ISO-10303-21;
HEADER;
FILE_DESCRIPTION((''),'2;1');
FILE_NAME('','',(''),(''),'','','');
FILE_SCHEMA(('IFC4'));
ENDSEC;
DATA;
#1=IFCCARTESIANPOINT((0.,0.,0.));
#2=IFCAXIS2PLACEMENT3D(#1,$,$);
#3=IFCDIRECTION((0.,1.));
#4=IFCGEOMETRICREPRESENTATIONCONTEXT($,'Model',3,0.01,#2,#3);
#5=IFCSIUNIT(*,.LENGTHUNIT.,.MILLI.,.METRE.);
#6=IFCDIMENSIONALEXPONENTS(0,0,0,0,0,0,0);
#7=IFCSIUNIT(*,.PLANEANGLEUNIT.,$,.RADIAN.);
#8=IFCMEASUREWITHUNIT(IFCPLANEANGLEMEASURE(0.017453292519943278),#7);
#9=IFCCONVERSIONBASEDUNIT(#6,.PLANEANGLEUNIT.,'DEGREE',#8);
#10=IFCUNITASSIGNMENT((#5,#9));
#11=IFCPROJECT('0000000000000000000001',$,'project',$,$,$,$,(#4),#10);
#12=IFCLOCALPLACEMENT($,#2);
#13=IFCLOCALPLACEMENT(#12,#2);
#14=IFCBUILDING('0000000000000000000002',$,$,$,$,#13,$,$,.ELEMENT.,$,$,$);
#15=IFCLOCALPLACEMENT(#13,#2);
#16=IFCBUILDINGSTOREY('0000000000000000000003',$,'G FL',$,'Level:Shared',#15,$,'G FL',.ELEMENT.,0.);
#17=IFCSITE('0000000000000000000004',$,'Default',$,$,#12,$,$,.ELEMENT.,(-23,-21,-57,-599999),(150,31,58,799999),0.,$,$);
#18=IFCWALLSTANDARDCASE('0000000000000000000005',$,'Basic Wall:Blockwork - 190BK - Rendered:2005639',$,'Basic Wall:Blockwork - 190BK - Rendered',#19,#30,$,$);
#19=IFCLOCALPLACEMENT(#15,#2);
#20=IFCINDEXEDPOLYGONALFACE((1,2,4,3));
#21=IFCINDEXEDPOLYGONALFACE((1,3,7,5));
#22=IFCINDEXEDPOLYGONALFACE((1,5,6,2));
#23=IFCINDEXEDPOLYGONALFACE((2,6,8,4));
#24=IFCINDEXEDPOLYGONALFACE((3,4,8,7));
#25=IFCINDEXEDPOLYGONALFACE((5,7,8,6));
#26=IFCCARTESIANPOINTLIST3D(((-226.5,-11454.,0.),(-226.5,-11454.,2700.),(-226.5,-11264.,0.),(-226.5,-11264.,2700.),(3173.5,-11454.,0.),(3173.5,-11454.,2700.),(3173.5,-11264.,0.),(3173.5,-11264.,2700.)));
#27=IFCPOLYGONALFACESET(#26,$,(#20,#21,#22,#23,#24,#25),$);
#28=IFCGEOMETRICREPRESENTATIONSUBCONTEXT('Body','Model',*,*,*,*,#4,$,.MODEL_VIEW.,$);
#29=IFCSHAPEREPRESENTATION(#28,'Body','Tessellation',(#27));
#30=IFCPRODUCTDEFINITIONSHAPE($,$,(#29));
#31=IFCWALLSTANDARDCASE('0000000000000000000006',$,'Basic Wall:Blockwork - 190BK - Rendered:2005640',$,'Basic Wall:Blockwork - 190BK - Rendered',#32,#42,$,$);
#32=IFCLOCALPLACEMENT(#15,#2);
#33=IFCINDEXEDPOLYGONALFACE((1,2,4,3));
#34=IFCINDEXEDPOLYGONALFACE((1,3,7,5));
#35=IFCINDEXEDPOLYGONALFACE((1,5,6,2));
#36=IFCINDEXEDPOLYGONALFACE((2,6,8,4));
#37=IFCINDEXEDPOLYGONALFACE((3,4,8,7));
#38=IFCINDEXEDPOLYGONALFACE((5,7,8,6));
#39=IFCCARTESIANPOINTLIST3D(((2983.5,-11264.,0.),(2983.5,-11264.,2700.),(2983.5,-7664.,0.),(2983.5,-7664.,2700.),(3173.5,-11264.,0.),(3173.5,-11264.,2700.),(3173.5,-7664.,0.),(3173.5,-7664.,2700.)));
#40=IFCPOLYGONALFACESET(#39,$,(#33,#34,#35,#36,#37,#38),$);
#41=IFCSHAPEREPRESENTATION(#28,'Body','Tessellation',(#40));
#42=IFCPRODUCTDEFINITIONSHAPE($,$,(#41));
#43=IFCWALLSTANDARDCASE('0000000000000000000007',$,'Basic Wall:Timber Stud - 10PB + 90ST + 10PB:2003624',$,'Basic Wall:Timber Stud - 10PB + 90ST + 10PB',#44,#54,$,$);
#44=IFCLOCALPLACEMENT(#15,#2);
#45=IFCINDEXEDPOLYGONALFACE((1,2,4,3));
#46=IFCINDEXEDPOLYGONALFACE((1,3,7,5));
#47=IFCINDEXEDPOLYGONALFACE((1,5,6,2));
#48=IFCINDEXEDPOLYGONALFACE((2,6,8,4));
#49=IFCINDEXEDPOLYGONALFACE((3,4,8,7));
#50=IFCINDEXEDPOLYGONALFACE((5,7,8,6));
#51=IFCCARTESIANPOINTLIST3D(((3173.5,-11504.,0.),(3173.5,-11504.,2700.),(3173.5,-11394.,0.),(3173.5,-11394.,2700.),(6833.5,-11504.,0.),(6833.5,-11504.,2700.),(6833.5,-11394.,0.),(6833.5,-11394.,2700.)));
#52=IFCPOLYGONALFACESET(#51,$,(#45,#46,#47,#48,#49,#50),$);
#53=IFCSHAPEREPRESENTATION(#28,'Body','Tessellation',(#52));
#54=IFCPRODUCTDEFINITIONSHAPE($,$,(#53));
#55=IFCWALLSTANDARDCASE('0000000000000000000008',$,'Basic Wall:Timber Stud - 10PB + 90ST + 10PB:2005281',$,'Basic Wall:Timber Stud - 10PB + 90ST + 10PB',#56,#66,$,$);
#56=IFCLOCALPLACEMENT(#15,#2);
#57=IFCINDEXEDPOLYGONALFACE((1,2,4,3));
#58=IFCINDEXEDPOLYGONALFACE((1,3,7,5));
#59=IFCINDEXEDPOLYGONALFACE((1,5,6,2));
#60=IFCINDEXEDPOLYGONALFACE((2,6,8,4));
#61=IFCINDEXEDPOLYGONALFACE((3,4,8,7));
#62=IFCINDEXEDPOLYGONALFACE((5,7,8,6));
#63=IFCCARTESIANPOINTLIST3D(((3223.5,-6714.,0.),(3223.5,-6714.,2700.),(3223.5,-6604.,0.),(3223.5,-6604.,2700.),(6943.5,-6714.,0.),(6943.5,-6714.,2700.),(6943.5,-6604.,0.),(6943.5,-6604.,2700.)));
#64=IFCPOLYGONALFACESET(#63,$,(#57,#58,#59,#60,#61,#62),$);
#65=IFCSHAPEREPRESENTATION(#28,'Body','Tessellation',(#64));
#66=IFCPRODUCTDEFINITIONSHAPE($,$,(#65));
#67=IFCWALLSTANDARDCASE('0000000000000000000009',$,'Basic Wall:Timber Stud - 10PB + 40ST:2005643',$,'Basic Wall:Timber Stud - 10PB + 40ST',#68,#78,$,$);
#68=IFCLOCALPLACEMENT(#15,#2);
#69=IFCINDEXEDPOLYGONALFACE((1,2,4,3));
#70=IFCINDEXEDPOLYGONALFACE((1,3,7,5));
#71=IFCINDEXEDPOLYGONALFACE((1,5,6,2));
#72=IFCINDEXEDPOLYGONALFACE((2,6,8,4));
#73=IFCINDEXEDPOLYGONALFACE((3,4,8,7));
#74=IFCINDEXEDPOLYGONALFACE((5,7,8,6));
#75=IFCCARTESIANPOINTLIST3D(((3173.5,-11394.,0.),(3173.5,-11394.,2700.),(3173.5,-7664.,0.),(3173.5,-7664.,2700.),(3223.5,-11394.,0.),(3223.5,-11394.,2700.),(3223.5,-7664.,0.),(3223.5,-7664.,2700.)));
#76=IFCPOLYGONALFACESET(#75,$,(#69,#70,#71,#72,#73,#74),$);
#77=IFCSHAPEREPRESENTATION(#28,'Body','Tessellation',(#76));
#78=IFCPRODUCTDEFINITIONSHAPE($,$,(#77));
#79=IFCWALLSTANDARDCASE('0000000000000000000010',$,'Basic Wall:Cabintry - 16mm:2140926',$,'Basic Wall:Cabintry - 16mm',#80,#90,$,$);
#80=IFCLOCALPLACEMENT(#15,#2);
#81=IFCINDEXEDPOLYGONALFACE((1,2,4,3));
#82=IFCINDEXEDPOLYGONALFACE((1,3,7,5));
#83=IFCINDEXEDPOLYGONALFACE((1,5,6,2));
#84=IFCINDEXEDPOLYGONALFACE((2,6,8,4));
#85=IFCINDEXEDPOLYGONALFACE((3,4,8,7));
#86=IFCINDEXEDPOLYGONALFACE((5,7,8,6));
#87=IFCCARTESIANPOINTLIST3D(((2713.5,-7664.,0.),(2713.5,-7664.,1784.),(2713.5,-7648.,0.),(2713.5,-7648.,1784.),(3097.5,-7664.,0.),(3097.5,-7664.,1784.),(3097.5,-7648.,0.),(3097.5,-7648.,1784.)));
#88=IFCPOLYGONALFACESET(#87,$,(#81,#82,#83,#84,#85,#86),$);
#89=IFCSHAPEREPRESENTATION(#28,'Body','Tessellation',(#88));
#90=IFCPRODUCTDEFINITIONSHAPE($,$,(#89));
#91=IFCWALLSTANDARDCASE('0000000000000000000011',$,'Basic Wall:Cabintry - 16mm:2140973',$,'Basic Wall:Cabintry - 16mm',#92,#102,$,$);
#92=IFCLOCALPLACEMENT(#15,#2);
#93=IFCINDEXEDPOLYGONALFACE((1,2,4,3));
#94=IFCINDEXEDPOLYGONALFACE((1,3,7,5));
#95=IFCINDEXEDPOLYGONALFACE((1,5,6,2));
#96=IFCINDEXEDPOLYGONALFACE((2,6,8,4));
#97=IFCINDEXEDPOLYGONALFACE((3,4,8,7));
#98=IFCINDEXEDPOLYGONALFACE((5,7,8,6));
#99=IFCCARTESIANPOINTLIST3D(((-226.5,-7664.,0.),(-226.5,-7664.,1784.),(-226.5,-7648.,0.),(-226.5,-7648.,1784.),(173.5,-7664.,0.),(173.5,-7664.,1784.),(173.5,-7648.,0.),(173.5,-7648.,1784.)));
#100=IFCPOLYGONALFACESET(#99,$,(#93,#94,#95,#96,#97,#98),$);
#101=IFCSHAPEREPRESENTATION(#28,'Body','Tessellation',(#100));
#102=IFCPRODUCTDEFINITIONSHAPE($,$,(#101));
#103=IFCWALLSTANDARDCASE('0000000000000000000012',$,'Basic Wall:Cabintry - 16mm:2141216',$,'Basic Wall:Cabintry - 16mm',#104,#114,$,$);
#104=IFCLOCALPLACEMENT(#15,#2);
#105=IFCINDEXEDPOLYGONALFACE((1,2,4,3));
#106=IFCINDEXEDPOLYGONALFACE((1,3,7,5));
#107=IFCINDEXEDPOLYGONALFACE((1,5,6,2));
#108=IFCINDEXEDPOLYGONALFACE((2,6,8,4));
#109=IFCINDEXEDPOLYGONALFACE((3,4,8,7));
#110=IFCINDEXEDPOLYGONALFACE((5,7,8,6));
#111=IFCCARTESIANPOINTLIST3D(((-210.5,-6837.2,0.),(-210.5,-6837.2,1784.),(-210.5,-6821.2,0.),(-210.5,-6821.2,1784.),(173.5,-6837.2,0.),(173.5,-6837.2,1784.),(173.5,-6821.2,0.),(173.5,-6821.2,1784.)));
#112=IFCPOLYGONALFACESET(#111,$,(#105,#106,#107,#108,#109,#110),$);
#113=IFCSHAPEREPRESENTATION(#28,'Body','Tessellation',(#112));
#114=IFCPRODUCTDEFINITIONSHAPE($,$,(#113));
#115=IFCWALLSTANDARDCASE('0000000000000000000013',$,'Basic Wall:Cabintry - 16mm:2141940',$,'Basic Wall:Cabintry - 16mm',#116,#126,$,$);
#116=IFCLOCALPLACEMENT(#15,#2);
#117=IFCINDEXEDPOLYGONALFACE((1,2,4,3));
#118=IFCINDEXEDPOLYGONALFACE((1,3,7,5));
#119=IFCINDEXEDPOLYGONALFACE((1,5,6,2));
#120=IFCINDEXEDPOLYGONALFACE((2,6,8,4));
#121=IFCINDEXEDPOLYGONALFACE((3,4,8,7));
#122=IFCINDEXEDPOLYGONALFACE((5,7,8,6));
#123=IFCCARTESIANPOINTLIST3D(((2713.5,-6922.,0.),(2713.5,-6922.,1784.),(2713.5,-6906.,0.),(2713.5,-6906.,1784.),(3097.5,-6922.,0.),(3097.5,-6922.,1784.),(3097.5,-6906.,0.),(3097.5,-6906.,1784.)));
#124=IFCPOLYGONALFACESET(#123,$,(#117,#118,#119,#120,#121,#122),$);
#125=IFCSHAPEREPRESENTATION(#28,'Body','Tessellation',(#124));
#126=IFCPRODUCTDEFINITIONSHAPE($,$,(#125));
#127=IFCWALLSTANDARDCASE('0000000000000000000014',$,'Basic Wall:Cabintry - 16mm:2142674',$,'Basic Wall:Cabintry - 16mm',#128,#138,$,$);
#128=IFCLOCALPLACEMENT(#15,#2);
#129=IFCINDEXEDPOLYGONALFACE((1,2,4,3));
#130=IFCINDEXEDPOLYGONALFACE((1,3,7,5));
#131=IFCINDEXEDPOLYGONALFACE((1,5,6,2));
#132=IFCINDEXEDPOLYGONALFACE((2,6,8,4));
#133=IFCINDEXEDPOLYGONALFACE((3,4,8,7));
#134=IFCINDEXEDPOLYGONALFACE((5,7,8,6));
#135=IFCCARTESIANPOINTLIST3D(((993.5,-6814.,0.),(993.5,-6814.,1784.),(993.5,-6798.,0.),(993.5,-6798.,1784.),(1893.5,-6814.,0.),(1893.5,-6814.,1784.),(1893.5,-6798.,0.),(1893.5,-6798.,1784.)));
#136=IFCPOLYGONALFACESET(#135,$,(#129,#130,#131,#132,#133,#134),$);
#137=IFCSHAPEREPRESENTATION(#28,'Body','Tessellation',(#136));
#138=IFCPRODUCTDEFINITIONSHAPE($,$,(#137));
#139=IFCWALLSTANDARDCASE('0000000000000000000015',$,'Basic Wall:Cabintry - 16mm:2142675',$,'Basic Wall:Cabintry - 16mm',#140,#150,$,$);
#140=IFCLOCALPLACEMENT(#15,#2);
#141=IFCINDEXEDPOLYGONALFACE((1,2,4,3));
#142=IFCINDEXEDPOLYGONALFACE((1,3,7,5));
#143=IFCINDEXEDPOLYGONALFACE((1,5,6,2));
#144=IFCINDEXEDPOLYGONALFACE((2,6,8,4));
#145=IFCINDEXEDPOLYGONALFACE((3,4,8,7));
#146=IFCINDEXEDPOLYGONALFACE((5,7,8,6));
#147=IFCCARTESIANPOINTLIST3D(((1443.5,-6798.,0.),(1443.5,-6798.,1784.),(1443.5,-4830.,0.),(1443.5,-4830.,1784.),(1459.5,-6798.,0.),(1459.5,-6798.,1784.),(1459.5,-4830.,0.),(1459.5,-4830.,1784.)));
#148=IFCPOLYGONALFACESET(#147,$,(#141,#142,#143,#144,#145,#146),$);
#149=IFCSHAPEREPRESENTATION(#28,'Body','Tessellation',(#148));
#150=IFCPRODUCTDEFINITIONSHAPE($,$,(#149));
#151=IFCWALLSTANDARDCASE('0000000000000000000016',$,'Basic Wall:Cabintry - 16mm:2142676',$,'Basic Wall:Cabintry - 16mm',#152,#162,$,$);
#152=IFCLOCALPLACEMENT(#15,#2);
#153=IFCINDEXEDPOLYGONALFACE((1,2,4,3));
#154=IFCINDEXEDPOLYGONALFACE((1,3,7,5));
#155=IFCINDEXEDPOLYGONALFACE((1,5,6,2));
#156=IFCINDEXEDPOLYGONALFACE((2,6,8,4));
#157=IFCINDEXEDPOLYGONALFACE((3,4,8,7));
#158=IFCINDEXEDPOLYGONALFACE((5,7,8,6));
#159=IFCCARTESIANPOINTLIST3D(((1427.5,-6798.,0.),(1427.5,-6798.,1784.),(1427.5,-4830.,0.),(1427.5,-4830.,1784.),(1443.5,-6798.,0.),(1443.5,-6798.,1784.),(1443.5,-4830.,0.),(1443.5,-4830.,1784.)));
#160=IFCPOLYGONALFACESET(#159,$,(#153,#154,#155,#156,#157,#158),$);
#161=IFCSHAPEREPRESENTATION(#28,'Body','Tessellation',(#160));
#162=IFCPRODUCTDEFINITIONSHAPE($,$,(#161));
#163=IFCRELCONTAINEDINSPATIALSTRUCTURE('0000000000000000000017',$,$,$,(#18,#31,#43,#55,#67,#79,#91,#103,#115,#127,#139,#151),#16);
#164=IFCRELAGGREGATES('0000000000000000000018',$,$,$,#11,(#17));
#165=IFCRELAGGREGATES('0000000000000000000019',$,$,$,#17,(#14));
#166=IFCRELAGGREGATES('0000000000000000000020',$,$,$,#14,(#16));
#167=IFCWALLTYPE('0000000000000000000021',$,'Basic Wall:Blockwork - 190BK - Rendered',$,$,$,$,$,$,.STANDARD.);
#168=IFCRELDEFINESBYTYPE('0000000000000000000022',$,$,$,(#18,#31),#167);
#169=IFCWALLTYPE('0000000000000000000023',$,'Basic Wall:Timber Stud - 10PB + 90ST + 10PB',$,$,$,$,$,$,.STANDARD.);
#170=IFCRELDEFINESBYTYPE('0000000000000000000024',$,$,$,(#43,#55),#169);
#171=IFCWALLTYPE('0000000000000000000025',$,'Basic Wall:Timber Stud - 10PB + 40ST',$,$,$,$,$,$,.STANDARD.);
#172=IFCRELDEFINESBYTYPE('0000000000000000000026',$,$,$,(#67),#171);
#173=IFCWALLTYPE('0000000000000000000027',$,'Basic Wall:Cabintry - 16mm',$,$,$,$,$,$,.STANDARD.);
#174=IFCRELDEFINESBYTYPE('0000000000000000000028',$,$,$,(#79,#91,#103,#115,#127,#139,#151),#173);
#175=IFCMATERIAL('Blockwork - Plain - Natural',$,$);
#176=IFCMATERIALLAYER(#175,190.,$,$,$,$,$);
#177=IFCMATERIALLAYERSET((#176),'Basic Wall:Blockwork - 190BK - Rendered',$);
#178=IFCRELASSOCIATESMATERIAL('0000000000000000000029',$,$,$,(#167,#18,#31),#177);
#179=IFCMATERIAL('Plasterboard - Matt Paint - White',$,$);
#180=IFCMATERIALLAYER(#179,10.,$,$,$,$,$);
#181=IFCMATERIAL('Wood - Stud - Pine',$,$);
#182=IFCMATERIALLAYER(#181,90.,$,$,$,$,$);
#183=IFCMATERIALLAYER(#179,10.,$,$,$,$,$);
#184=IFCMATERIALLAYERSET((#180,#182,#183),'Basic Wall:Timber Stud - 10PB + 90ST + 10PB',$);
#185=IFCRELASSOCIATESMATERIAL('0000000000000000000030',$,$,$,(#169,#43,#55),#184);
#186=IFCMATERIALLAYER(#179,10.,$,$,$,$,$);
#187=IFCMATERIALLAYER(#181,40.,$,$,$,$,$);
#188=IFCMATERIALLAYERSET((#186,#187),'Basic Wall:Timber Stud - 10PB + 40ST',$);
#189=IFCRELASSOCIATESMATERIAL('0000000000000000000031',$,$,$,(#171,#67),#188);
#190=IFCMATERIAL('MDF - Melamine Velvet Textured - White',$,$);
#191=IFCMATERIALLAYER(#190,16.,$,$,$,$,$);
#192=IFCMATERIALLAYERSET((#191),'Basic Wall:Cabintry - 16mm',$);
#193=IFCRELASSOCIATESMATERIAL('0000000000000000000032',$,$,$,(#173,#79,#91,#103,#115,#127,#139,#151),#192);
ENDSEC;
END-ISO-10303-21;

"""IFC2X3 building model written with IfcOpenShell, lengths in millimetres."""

from ifc_helpers import new_model, entity, si_unit, converted_unit, direction, frame, frame_2d, origin, place, context, subcontext, project, spatial, polyline, rectangle, extrude, clip, bounded_halfspace, material, layer, layer_set, layer_usage, type_object, element, save


model = new_model("IFC2X3")

# Units and contexts
model_context = context("Model", 3, precision=0.01, world=origin(), true_north=direction((0.0, 1.0)))
body_context = subcontext(model_context, "Body", "Model", "MODEL_VIEW")
ifc_project = project(units=[si_unit("LENGTHUNIT", "METRE", prefix="MILLI"), converted_unit("PLANEANGLEUNIT", "DEGREE", entity("IfcPlaneAngleMeasure", 0.017453292519943278), si_unit("PLANEANGLEUNIT", "RADIAN"), dimensions=[0, 0, 0, 0, 0, 0, 0])], contexts=[model_context])

# Site, building, storey
site_placement = place(None, origin())
site = spatial("IfcSite", under=ifc_project, at=site_placement, Name="Default", CompositionType="ELEMENT", RefLatitude=(-23, -21, -57, -599999), RefLongitude=(150, 31, 58, 799999), RefElevation=0.0)
building_placement = place(site_placement, origin())
building = spatial("IfcBuilding", under=site, at=building_placement, CompositionType="ELEMENT")
storey_placement = place(building_placement, origin())
storey = spatial("IfcBuildingStorey", under=building, at=storey_placement, Name="G FL", ObjectType="Level:Shared", LongName="G FL", CompositionType="ELEMENT", Elevation=0.0)

# Walls
ifc_material_1 = material(Name="Blockwork - Plain - Natural")
ifc_layer_1 = layer(ifc_material_1, 190.0)
ifc_layer_set_1 = layer_set([ifc_layer_1], Name="Basic Wall:Blockwork - 190BK - Rendered")
ifc_layer_usage_1 = layer_usage(ifc_layer_set_1, "AXIS2", "POSITIVE", -95.0)
wall_type_1 = type_object("IfcWallType", Name="Basic Wall:Blockwork - 190BK - Rendered", PredefinedType="STANDARD", material=ifc_layer_set_1)
wall_1_placement = place(storey_placement, frame((3173.5, -11359.0, 0.0), z_axis=(0.0, 0.0, 1.0), x_axis=(-1.0, 0.0, 0.0)))
element("IfcWallStandardCase", 1, at=wall_1_placement, inside=storey, type_object=wall_type_1, material=ifc_layer_usage_1, Name="Basic Wall:Blockwork - 190BK - Rendered:2005639", ObjectType="Basic Wall:Blockwork - 190BK - Rendered", context=body_context, shape_type="SweptSolid", body=[
    extrude(rectangle(XDim=3400.0, YDim=190.0, at=frame_2d((1700.0, 0.0), x_axis=(-1.0, 0.0))), origin(), (0.0, 0.0, 1.0), 2700.0),
])
ifc_layer_usage_2 = layer_usage(ifc_layer_set_1, "AXIS2", "POSITIVE", -95.0)
wall_2_placement = place(storey_placement, frame((3078.5, -7664.0, 0.0), z_axis=(0.0, 0.0, 1.0), x_axis=(0.0, -1.0, 0.0)))
element("IfcWallStandardCase", 2, at=wall_2_placement, inside=storey, type_object=wall_type_1, material=ifc_layer_usage_2, Name="Basic Wall:Blockwork - 190BK - Rendered:2005640", ObjectType="Basic Wall:Blockwork - 190BK - Rendered", context=body_context, shape_type="SweptSolid", body=[
    extrude(rectangle(XDim=3600.0, YDim=190.0, at=frame_2d((1800.0, 0.0), x_axis=(-1.0, 0.0))), origin(), (0.0, 0.0, 1.0), 2700.0),
])
ifc_material_2 = material(Name="Plasterboard - Matt Paint - White")
ifc_layer_2 = layer(ifc_material_2, 10.0)
ifc_material_3 = material(Name="Wood - Stud - Pine")
ifc_layer_3 = layer(ifc_material_3, 90.0)
ifc_layer_4 = layer(ifc_material_2, 10.0)
ifc_layer_set_2 = layer_set([ifc_layer_2, ifc_layer_3, ifc_layer_4], Name="Basic Wall:Timber Stud - 10PB + 90ST + 10PB")
ifc_layer_usage_3 = layer_usage(ifc_layer_set_2, "AXIS2", "POSITIVE", -55.0)
wall_type_2 = type_object("IfcWallType", Name="Basic Wall:Timber Stud - 10PB + 90ST + 10PB", PredefinedType="STANDARD", material=ifc_layer_set_2)
wall_3_placement = place(storey_placement, frame((6833.5, -11449.0, 0.0), z_axis=(0.0, 0.0, 1.0), x_axis=(-1.0, 0.0, 0.0)))
element("IfcWallStandardCase", 3, at=wall_3_placement, inside=storey, type_object=wall_type_2, material=ifc_layer_usage_3, Name="Basic Wall:Timber Stud - 10PB + 90ST + 10PB:2003624", ObjectType="Basic Wall:Timber Stud - 10PB + 90ST + 10PB", context=body_context, shape_type="SweptSolid", body=[
    extrude(rectangle(XDim=3660.0, YDim=110.0, at=frame_2d((1830.0, 0.0), x_axis=(-1.0, 0.0))), origin(), (0.0, 0.0, 1.0), 2700.0),
])
ifc_layer_usage_4 = layer_usage(ifc_layer_set_2, "AXIS2", "POSITIVE", -55.0)
wall_4_placement = place(storey_placement, frame((3223.5, -6659.0, 0.0)))
element("IfcWallStandardCase", 4, at=wall_4_placement, inside=storey, type_object=wall_type_2, material=ifc_layer_usage_4, Name="Basic Wall:Timber Stud - 10PB + 90ST + 10PB:2005281", ObjectType="Basic Wall:Timber Stud - 10PB + 90ST + 10PB", context=body_context, shape_type="SweptSolid", body=[
    extrude(rectangle(XDim=3720.0, YDim=110.0, at=frame_2d((1860.0, 0.0), x_axis=(-1.0, 0.0))), origin(), (0.0, 0.0, 1.0), 2700.0),
])
ifc_layer_5 = layer(ifc_material_2, 10.0)
ifc_layer_6 = layer(ifc_material_3, 40.0)
ifc_layer_set_3 = layer_set([ifc_layer_5, ifc_layer_6], Name="Basic Wall:Timber Stud - 10PB + 40ST")
ifc_layer_usage_5 = layer_usage(ifc_layer_set_3, "AXIS2", "NEGATIVE", 25.0)
wall_type_3 = type_object("IfcWallType", Name="Basic Wall:Timber Stud - 10PB + 40ST", PredefinedType="STANDARD", material=ifc_layer_set_3)
wall_5_placement = place(storey_placement, frame((3198.5, -7664.0, 0.0), z_axis=(0.0, 0.0, 1.0), x_axis=(0.0, -1.0, 0.0)))
element("IfcWallStandardCase", 5, at=wall_5_placement, inside=storey, type_object=wall_type_3, material=ifc_layer_usage_5, Name="Basic Wall:Timber Stud - 10PB + 40ST:2005643", ObjectType="Basic Wall:Timber Stud - 10PB + 40ST", context=body_context, shape_type="SweptSolid", body=[
    extrude(rectangle(XDim=3730.0, YDim=50.0, at=frame_2d((1865.0, 0.0), x_axis=(-1.0, 0.0))), origin(), (0.0, 0.0, 1.0), 2700.0),
])
ifc_material_4 = material(Name="MDF - Melamine Velvet Textured - White")
ifc_layer_7 = layer(ifc_material_4, 16.0)
ifc_layer_set_4 = layer_set([ifc_layer_7], Name="Basic Wall:Cabintry - 16mm")
ifc_layer_usage_6 = layer_usage(ifc_layer_set_4, "AXIS2", "NEGATIVE", 8.0)
wall_type_4 = type_object("IfcWallType", Name="Basic Wall:Cabintry - 16mm", PredefinedType="STANDARD", material=ifc_layer_set_4)
wall_6_placement = place(storey_placement, frame((3097.5, -7656.0, 0.0), z_axis=(0.0, 0.0, 1.0), x_axis=(-1.0, 0.0, 0.0)))
element("IfcWallStandardCase", 6, at=wall_6_placement, inside=storey, type_object=wall_type_4, material=ifc_layer_usage_6, Name="Basic Wall:Cabintry - 16mm:2140926", ObjectType="Basic Wall:Cabintry - 16mm", context=body_context, shape_type="Clipping", body=[
    clip(extrude(rectangle(XDim=384.0, YDim=16.0, at=frame_2d((192.0, 0.0), x_axis=(-1.0, 0.0))), origin(), (0.0, 0.0, 1.0), 1784.0), bounded_halfspace(frame((0.0, -8.0, 1784.0), z_axis=(0.0, 0.0, -1.0), x_axis=(-1.0, 0.0, 0.0)), True, frame((0.0, -8.0, 1784.0)), polyline([(0.0, 0.0), (384.0, 0.0), (384.0, 16.0), (0.0, 16.0), (0.0, 0.0)]))),
])
ifc_layer_usage_7 = layer_usage(ifc_layer_set_4, "AXIS2", "NEGATIVE", 8.0)
wall_7_placement = place(storey_placement, frame((173.5, -7656.0, 0.0), z_axis=(0.0, 0.0, 1.0), x_axis=(-1.0, 0.0, 0.0)))
element("IfcWallStandardCase", 7, at=wall_7_placement, inside=storey, type_object=wall_type_4, material=ifc_layer_usage_7, Name="Basic Wall:Cabintry - 16mm:2140973", ObjectType="Basic Wall:Cabintry - 16mm", context=body_context, shape_type="Clipping", body=[
    clip(extrude(rectangle(XDim=400.0, YDim=16.0, at=frame_2d((200.0, 0.0), x_axis=(-1.0, 0.0))), origin(), (0.0, 0.0, 1.0), 1784.0), bounded_halfspace(frame((0.0, -8.0, 1784.0), z_axis=(0.0, 0.0, -1.0), x_axis=(-1.0, 0.0, 0.0)), True, frame((0.0, -8.0, 1784.0)), polyline([(0.0, 0.0), (384.0, 0.0), (400.0, 0.0), (400.0, 16.0), (0.0, 16.0), (0.0, 0.0)]))),
])
ifc_layer_usage_8 = layer_usage(ifc_layer_set_4, "AXIS2", "NEGATIVE", 8.0)
wall_8_placement = place(storey_placement, frame((173.5, -6829.2, 0.0), z_axis=(0.0, 0.0, 1.0), x_axis=(-1.0, 0.0, 0.0)))
element("IfcWallStandardCase", 8, at=wall_8_placement, inside=storey, type_object=wall_type_4, material=ifc_layer_usage_8, Name="Basic Wall:Cabintry - 16mm:2141216", ObjectType="Basic Wall:Cabintry - 16mm", context=body_context, shape_type="Clipping", body=[
    clip(extrude(rectangle(XDim=384.0, YDim=16.0, at=frame_2d((192.0, 0.0), x_axis=(-1.0, 0.0))), origin(), (0.0, 0.0, 1.0), 1784.0), bounded_halfspace(frame((0.0, -8.0, 1784.0), z_axis=(0.0, 0.0, -1.0), x_axis=(-1.0, 0.0, 0.0)), True, frame((0.0, -8.0, 1784.0)), polyline([(0.0, 0.0), (384.0, 0.0), (384.0, 16.0), (0.0, 16.0), (0.0, 0.0)]))),
])
ifc_layer_usage_9 = layer_usage(ifc_layer_set_4, "AXIS2", "NEGATIVE", 8.0)
wall_9_placement = place(storey_placement, frame((2713.5, -6914.0, 0.0)))
element("IfcWallStandardCase", 9, at=wall_9_placement, inside=storey, type_object=wall_type_4, material=ifc_layer_usage_9, Name="Basic Wall:Cabintry - 16mm:2141940", ObjectType="Basic Wall:Cabintry - 16mm", context=body_context, shape_type="Clipping", body=[
    clip(extrude(rectangle(XDim=384.0, YDim=16.0, at=frame_2d((192.0, 0.0), x_axis=(-1.0, 0.0))), origin(), (0.0, 0.0, 1.0), 1784.0), bounded_halfspace(frame((0.0, -8.0, 1784.0), z_axis=(0.0, 0.0, -1.0), x_axis=(1.0, 0.0, 0.0)), True, frame((0.0, -8.0, 1784.0)), polyline([(0.0, 0.0), (384.0, 0.0), (384.0, 16.0), (0.0, 16.0), (0.0, 0.0)]))),
])
ifc_layer_usage_10 = layer_usage(ifc_layer_set_4, "AXIS2", "NEGATIVE", 8.0)
wall_10_placement = place(storey_placement, frame((1893.5, -6806.0, 0.0), z_axis=(0.0, 0.0, 1.0), x_axis=(-1.0, 0.0, 0.0)))
element("IfcWallStandardCase", 10, at=wall_10_placement, inside=storey, type_object=wall_type_4, material=ifc_layer_usage_10, Name="Basic Wall:Cabintry - 16mm:2142674", ObjectType="Basic Wall:Cabintry - 16mm", context=body_context, shape_type="SweptSolid", body=[
    extrude(rectangle(XDim=900.0, YDim=16.0, at=frame_2d((450.0, 0.0), x_axis=(-1.0, 0.0))), origin(), (0.0, 0.0, 1.0), 1784.0),
])
ifc_layer_usage_11 = layer_usage(ifc_layer_set_4, "AXIS2", "NEGATIVE", 8.0)
wall_11_placement = place(storey_placement, frame((1451.5, -6798.0, 0.0), z_axis=(0.0, 0.0, 1.0), x_axis=(0.0, 1.0, 0.0)))
element("IfcWallStandardCase", 11, at=wall_11_placement, inside=storey, type_object=wall_type_4, material=ifc_layer_usage_11, Name="Basic Wall:Cabintry - 16mm:2142675", ObjectType="Basic Wall:Cabintry - 16mm", context=body_context, shape_type="Clipping", body=[
    clip(extrude(rectangle(XDim=1968.0, YDim=16.0, at=frame_2d((984.0, 0.0), x_axis=(-1.0, 0.0))), origin(), (0.0, 0.0, 1.0), 1784.0), bounded_halfspace(frame((0.0, -8.0, 1784.0), z_axis=(0.0, 0.0, -1.0), x_axis=(-1.0, 0.0, 0.0)), True, frame((0.0, -8.0, 1784.0)), polyline([(0.0, 0.0), (968.0, 0.0), (984.0, 0.0), (1000.0, 0.0), (1968.0, 0.0), (1968.0, 16.0), (0.0, 16.0), (0.0, 0.0)]))),
])
ifc_layer_usage_12 = layer_usage(ifc_layer_set_4, "AXIS2", "POSITIVE", -8.0)
wall_12_placement = place(storey_placement, frame((1435.5, -6798.0, 0.0), z_axis=(0.0, 0.0, 1.0), x_axis=(0.0, 1.0, 0.0)))
element("IfcWallStandardCase", 12, at=wall_12_placement, inside=storey, type_object=wall_type_4, material=ifc_layer_usage_12, Name="Basic Wall:Cabintry - 16mm:2142676", ObjectType="Basic Wall:Cabintry - 16mm", context=body_context, shape_type="Clipping", body=[
    clip(extrude(rectangle(XDim=1968.0, YDim=16.0, at=frame_2d((984.0, 0.0), x_axis=(-1.0, 0.0))), origin(), (0.0, 0.0, 1.0), 1784.0), bounded_halfspace(frame((0.0, -8.0, 1784.0), z_axis=(0.0, 0.0, -1.0), x_axis=(0.0, -1.0, 0.0)), True, frame((0.0, -8.0, 1784.0)), polyline([(0.0, 0.0), (1968.0, 0.0), (1968.0, 16.0), (1000.0, 16.0), (984.0, 16.0), (968.0, 16.0), (0.0, 16.0), (0.0, 0.0)]))),
])

save(model, "model.ifc")
